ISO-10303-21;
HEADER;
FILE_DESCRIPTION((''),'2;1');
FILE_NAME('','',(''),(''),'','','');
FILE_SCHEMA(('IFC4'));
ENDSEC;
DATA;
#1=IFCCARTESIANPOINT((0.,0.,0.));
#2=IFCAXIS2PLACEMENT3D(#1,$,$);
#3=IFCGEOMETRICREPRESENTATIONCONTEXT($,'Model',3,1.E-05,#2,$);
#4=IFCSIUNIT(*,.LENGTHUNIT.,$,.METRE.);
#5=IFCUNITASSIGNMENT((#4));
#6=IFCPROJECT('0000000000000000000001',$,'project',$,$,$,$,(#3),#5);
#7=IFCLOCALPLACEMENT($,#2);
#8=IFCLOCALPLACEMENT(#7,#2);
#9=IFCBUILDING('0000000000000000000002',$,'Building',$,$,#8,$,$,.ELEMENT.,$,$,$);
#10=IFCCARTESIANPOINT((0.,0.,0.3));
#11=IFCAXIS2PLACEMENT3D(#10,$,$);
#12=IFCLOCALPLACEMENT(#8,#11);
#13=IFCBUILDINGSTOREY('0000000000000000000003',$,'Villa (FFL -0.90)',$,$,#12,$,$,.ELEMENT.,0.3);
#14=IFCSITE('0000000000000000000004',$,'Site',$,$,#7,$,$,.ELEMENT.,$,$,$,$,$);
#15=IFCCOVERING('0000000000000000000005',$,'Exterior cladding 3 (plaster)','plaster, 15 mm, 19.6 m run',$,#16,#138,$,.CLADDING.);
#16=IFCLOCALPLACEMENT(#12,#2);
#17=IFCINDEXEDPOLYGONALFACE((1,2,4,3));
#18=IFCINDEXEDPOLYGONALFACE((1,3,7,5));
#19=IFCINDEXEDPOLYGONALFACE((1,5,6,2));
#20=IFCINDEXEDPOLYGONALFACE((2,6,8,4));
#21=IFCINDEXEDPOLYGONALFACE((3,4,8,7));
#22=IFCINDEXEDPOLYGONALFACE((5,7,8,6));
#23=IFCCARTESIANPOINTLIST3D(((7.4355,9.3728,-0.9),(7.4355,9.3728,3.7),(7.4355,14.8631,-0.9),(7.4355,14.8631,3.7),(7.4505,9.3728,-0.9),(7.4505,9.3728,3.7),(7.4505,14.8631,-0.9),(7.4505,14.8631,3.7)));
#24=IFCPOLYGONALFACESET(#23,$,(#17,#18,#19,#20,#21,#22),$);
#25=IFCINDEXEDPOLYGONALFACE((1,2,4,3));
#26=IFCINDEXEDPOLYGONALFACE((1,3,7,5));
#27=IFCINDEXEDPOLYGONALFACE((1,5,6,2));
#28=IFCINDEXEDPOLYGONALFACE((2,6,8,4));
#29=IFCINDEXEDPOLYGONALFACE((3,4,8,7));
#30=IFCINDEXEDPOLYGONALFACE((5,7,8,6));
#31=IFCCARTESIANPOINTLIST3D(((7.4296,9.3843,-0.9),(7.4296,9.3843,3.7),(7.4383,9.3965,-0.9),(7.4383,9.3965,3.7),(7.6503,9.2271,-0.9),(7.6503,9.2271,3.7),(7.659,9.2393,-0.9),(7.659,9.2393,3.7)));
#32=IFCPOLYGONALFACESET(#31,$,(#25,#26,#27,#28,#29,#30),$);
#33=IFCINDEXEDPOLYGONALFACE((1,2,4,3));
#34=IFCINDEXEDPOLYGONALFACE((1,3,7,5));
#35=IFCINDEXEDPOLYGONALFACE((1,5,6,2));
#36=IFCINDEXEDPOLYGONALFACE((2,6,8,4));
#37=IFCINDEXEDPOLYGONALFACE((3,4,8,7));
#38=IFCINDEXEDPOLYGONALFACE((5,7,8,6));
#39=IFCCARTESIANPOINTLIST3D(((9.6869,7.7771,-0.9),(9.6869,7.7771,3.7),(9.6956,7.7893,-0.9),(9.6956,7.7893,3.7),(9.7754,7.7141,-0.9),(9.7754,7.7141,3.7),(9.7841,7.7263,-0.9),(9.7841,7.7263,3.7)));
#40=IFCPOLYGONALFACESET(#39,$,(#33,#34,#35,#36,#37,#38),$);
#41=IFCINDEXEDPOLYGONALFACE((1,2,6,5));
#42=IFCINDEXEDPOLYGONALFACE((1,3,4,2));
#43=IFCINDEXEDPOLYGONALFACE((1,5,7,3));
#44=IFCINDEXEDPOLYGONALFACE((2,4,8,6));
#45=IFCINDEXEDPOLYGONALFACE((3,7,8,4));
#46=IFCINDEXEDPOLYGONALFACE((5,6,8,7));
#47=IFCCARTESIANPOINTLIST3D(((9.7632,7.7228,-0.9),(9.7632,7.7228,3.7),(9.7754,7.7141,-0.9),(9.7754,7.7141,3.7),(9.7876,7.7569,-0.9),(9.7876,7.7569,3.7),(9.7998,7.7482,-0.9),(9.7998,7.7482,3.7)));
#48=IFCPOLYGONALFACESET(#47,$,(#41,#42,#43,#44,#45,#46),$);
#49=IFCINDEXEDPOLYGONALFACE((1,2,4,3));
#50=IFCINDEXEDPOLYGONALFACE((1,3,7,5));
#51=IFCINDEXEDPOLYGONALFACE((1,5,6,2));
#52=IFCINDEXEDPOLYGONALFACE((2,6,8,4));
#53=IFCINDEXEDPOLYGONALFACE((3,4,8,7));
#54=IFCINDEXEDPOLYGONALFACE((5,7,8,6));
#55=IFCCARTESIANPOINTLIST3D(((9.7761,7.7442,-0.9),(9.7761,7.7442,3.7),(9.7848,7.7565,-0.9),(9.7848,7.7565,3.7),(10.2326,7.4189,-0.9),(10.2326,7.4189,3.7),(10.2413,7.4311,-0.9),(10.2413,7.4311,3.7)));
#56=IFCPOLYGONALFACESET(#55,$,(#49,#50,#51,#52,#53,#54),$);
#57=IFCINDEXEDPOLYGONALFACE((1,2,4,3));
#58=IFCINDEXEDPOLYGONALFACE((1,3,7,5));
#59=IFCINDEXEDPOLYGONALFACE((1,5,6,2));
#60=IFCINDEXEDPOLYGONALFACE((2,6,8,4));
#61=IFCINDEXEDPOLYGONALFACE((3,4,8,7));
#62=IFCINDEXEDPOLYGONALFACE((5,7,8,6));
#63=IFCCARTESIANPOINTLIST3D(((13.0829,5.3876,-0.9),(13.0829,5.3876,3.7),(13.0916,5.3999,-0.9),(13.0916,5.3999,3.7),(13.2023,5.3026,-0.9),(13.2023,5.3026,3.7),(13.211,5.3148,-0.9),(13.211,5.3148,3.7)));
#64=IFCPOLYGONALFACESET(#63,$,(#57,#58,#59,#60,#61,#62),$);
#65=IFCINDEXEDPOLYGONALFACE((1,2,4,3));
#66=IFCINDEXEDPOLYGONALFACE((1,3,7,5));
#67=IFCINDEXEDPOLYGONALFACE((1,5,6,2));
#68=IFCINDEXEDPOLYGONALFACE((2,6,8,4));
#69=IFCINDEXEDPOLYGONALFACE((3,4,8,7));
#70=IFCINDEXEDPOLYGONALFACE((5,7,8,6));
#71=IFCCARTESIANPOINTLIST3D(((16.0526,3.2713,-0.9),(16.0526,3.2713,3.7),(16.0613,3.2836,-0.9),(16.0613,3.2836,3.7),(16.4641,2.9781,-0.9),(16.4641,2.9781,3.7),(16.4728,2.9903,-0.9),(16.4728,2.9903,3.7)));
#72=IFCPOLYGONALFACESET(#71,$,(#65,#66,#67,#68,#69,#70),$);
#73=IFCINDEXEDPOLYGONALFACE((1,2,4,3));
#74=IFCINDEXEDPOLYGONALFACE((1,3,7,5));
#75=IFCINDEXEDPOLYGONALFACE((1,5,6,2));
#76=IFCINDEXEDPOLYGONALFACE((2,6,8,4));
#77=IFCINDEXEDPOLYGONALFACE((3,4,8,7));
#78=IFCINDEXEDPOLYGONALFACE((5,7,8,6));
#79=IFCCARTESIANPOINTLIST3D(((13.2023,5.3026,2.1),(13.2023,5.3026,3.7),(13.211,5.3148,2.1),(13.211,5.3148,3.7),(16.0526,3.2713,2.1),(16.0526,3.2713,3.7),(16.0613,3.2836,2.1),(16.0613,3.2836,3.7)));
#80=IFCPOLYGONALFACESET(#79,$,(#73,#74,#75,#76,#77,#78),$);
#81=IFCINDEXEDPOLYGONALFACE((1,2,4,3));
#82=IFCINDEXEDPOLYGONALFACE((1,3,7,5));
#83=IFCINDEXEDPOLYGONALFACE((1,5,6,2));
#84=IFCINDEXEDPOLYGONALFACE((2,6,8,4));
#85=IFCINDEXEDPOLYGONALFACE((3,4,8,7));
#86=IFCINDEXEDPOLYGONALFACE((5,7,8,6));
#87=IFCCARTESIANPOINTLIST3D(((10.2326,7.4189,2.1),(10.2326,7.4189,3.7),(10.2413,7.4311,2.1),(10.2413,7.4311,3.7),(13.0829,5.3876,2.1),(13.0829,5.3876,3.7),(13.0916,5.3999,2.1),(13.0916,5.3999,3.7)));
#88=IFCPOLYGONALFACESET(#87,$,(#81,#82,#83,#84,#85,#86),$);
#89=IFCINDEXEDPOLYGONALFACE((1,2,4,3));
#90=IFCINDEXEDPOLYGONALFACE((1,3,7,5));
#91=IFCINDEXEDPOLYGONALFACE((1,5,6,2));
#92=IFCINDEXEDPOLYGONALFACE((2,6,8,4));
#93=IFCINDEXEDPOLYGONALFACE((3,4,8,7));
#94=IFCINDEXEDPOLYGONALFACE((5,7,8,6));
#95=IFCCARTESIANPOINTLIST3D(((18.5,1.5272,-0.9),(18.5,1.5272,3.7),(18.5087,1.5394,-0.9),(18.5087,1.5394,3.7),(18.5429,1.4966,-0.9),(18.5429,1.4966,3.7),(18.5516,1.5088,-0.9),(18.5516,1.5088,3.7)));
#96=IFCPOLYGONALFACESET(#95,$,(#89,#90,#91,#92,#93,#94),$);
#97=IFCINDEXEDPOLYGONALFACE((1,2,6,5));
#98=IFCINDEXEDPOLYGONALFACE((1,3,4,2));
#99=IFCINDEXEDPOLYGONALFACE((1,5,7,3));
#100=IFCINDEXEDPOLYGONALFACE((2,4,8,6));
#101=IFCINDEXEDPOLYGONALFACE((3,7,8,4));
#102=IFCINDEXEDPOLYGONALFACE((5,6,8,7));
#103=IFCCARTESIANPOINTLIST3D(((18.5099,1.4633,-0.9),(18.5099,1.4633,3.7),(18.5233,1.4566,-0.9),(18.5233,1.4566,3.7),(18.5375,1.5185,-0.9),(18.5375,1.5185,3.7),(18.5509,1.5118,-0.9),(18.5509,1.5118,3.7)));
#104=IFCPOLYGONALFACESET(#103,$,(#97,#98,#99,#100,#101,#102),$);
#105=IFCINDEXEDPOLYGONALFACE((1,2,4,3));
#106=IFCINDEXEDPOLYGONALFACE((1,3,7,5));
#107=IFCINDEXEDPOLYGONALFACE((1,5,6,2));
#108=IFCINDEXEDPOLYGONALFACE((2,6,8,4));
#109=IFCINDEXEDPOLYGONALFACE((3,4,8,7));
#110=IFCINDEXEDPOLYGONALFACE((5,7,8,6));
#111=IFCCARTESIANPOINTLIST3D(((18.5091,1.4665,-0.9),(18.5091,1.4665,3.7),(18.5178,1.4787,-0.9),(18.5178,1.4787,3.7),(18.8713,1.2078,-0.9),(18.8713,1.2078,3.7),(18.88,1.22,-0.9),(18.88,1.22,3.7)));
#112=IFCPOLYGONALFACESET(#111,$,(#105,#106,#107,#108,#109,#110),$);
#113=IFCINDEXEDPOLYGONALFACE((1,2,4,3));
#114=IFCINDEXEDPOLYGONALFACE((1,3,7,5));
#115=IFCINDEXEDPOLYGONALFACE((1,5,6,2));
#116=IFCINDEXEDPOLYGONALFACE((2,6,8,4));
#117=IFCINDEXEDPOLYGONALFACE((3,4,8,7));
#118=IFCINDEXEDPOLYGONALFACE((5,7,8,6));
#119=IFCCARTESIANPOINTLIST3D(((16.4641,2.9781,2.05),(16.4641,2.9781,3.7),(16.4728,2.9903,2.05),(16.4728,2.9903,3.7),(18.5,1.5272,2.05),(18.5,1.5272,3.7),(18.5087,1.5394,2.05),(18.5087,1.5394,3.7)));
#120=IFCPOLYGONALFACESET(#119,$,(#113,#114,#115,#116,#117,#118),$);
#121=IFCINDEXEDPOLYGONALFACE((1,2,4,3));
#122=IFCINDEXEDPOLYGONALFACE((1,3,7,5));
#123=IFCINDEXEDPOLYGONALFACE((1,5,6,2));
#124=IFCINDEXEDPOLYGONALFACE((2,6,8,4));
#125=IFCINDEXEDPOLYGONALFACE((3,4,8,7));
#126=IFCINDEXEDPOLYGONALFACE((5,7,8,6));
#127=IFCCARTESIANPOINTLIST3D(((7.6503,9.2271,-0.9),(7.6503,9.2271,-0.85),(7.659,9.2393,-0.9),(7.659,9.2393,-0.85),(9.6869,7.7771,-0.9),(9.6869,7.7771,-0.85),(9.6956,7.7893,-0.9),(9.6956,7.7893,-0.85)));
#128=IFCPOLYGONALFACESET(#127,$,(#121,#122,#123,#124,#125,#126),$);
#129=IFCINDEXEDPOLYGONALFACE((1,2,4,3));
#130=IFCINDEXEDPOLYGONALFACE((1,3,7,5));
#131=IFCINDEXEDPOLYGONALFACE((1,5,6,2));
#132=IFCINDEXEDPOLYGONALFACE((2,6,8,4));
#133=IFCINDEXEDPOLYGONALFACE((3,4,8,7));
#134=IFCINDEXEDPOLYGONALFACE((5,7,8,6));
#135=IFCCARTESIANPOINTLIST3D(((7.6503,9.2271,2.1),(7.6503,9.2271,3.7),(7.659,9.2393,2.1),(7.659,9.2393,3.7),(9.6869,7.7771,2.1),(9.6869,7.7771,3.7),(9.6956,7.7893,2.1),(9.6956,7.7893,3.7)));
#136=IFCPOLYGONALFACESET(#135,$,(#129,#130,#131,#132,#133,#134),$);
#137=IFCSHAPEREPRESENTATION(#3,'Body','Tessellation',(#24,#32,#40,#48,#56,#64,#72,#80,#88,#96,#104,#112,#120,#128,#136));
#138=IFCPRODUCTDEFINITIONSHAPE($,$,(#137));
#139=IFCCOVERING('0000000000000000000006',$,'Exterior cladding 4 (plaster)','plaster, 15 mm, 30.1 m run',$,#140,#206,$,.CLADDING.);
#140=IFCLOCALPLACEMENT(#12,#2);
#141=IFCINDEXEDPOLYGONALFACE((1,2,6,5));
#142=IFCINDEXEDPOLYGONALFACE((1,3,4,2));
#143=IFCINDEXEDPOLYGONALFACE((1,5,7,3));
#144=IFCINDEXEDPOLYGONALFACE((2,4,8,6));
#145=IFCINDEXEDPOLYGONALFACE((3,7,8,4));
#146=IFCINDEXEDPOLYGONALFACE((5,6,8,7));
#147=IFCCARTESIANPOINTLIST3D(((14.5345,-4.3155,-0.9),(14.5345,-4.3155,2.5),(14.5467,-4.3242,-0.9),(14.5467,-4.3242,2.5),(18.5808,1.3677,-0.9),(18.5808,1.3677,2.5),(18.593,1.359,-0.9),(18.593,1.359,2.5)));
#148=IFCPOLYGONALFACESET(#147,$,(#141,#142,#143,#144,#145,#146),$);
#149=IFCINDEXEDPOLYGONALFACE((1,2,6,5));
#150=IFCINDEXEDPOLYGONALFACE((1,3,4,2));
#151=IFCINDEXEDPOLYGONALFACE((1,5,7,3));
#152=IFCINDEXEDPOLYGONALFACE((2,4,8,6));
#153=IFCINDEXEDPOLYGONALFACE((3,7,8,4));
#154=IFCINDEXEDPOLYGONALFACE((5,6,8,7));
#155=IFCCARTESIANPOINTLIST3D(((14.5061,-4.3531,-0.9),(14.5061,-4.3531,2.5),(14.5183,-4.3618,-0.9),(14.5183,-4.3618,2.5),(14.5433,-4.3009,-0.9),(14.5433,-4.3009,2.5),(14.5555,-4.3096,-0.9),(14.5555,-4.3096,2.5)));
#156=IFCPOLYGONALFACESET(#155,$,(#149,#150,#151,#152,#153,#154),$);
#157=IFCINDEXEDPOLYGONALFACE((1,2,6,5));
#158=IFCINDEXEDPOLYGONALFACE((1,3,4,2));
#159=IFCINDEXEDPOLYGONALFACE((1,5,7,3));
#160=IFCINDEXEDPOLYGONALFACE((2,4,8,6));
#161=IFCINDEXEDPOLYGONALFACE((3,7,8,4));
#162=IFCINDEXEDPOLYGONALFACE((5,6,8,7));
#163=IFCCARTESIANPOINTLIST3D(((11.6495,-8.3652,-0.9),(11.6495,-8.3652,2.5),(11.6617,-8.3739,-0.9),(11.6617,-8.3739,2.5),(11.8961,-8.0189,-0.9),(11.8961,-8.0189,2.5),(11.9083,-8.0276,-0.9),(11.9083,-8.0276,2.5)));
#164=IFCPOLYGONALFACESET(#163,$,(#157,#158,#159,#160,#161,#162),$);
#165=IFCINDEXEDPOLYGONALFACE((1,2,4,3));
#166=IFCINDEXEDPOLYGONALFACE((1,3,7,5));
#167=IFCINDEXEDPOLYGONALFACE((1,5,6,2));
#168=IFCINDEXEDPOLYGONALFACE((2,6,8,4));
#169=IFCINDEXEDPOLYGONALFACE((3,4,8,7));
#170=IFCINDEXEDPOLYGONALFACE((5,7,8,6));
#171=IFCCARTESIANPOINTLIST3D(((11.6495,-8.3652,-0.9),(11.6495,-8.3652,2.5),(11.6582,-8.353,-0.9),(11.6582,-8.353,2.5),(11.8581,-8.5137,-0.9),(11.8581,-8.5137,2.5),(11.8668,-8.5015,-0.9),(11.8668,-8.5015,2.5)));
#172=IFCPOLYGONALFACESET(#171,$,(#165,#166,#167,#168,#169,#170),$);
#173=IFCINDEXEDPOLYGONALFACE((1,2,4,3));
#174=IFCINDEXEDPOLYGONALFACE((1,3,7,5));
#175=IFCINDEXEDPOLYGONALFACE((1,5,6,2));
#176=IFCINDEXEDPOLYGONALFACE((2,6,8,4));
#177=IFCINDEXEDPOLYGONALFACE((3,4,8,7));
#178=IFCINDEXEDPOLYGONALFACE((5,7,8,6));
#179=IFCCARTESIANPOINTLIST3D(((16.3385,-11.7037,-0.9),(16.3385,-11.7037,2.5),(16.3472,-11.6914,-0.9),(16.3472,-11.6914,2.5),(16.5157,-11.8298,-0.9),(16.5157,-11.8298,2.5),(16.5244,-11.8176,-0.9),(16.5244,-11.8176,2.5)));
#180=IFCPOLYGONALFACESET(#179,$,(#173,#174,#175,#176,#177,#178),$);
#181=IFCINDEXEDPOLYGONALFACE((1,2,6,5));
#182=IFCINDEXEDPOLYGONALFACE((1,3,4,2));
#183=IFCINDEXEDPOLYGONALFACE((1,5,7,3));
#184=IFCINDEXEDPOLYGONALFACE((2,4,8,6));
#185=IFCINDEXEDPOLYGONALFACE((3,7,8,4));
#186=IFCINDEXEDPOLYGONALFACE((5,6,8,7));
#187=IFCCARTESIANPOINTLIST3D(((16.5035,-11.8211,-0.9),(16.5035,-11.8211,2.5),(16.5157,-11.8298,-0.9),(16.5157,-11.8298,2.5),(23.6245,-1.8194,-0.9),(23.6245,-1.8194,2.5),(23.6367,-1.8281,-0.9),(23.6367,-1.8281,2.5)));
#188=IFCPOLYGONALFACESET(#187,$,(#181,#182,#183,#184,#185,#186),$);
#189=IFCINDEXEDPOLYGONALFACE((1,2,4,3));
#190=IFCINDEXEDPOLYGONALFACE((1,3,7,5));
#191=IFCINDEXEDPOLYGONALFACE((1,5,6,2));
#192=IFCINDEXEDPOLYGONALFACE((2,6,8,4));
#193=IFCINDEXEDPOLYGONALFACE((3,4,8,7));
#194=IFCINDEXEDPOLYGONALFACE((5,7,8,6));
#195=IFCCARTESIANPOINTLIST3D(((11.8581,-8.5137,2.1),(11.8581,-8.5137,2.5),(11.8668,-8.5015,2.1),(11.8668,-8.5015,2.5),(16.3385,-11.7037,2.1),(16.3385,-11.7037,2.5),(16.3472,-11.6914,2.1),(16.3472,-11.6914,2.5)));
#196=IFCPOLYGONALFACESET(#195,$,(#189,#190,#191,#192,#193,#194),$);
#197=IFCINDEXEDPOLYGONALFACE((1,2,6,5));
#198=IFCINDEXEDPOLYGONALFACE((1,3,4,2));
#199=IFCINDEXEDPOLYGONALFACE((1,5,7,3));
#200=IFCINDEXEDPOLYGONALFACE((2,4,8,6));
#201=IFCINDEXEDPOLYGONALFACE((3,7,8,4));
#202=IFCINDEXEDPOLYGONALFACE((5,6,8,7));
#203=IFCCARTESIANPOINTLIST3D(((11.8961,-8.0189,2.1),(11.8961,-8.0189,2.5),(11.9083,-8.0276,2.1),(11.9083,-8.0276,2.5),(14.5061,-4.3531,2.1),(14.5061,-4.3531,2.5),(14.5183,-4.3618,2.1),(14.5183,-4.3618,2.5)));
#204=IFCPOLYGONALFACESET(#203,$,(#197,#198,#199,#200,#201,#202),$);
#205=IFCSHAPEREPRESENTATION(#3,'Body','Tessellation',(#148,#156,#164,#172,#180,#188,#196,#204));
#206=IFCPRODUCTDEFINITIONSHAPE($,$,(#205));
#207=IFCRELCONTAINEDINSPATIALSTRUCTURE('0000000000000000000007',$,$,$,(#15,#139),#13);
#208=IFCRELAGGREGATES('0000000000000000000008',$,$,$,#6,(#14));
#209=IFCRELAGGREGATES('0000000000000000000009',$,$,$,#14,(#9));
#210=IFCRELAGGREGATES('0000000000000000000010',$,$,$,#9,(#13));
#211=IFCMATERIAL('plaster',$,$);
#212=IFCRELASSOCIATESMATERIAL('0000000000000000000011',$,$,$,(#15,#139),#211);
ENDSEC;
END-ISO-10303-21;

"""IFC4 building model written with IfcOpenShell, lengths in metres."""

from ifc_helpers import new_model, si_unit, frame, origin, origin_with_axes, place, context, project, spatial, polyline, outline, extrude, material, element, save


model = new_model("IFC4")

# Units and contexts
model_context = context("Model", 3, precision=1e-05, world=origin())
ifc_project = project(units=[si_unit("LENGTHUNIT", "METRE")], contexts=[model_context])

# Site, building, storey
site_placement = place(None, origin())
site = spatial("IfcSite", under=ifc_project, at=site_placement, Name="Site", CompositionType="ELEMENT")
building_placement = place(site_placement, origin())
building = spatial("IfcBuilding", under=site, at=building_placement, Name="Building", CompositionType="ELEMENT")
storey_placement = place(building_placement, frame((0.0, 0.0, 0.3)))
storey = spatial("IfcBuildingStorey", under=building, at=storey_placement, Name="Villa (FFL -0.90)", CompositionType="ELEMENT", Elevation=0.3)

# Coverings
ifc_material_1 = material(Name="plaster")
covering_1_placement = place(storey_placement, origin_with_axes())
element("IfcCovering", 1, at=covering_1_placement, inside=storey, material=ifc_material_1, Name="Exterior cladding 3 (plaster)", Description="plaster, 15 mm, 19.6 m run", PredefinedType="CLADDING", context=model_context, shape_type="SweptSolid", body=[
    extrude(outline(polyline([(7.4355, 14.8631), (7.4355, 9.3728), (7.4505, 9.3728), (7.4505, 14.8631), (7.4355, 14.8631)])), frame((0.0, 0.0, -0.9)), (0.0, 0.0, 1.0), 4.6),
    extrude(outline(polyline([(7.4296, 9.3843), (7.6503, 9.2271), (7.659, 9.2393), (7.4383, 9.3965), (7.4296, 9.3843)])), frame((0.0, 0.0, -0.9)), (0.0, 0.0, 1.0), 4.6),
    extrude(outline(polyline([(9.6869, 7.7771), (9.7754, 7.7141), (9.7841, 7.7263), (9.6956, 7.7893), (9.6869, 7.7771)])), frame((0.0, 0.0, -0.9)), (0.0, 0.0, 1.0), 4.6),
    extrude(outline(polyline([(9.7754, 7.7141), (9.7998, 7.7482), (9.7876, 7.7569), (9.7632, 7.7228), (9.7754, 7.7141)])), frame((0.0, 0.0, -0.9)), (0.0, 0.0, 1.0), 4.6),
    extrude(outline(polyline([(9.7761, 7.7442), (10.2326, 7.4189), (10.2413, 7.4311), (9.7848, 7.7565), (9.7761, 7.7442)])), frame((0.0, 0.0, -0.9)), (0.0, 0.0, 1.0), 4.6),
    extrude(outline(polyline([(13.0829, 5.3876), (13.2023, 5.3026), (13.211, 5.3148), (13.0916, 5.3999), (13.0829, 5.3876)])), frame((0.0, 0.0, -0.9)), (0.0, 0.0, 1.0), 4.6),
    extrude(outline(polyline([(16.0526, 3.2713), (16.4641, 2.9781), (16.4728, 2.9903), (16.0613, 3.2836), (16.0526, 3.2713)])), frame((0.0, 0.0, -0.9)), (0.0, 0.0, 1.0), 4.6),
    extrude(outline(polyline([(13.2023, 5.3026), (16.0526, 3.2713), (16.0613, 3.2836), (13.211, 5.3148), (13.2023, 5.3026)])), frame((0.0, 0.0, 2.1)), (0.0, 0.0, 1.0), 1.6),
    extrude(outline(polyline([(10.2326, 7.4189), (13.0829, 5.3876), (13.0916, 5.3999), (10.2413, 7.4311), (10.2326, 7.4189)])), frame((0.0, 0.0, 2.1)), (0.0, 0.0, 1.0), 1.6),
    extrude(outline(polyline([(18.5, 1.5272), (18.5429, 1.4966), (18.5516, 1.5088), (18.5087, 1.5394), (18.5, 1.5272)])), frame((0.0, 0.0, -0.9)), (0.0, 0.0, 1.0), 4.6),
    extrude(outline(polyline([(18.5375, 1.5185), (18.5099, 1.4633), (18.5233, 1.4566), (18.5509, 1.5118), (18.5375, 1.5185)])), frame((0.0, 0.0, -0.9)), (0.0, 0.0, 1.0), 4.6),
    extrude(outline(polyline([(18.5091, 1.4665), (18.8713, 1.2078), (18.88, 1.22), (18.5178, 1.4787), (18.5091, 1.4665)])), frame((0.0, 0.0, -0.9)), (0.0, 0.0, 1.0), 4.6),
    extrude(outline(polyline([(16.4641, 2.9781), (18.5, 1.5272), (18.5087, 1.5394), (16.4728, 2.9903), (16.4641, 2.9781)])), frame((0.0, 0.0, 2.05)), (0.0, 0.0, 1.0), 1.65),
    extrude(outline(polyline([(7.6503, 9.2271), (9.6869, 7.7771), (9.6956, 7.7893), (7.659, 9.2393), (7.6503, 9.2271)])), frame((0.0, 0.0, -0.9)), (0.0, 0.0, 1.0), 0.05),
    extrude(outline(polyline([(7.6503, 9.2271), (9.6869, 7.7771), (9.6956, 7.7893), (7.659, 9.2393), (7.6503, 9.2271)])), frame((0.0, 0.0, 2.1)), (0.0, 0.0, 1.0), 1.6),
])
covering_2_placement = place(storey_placement, origin_with_axes())
element("IfcCovering", 2, at=covering_2_placement, inside=storey, material=ifc_material_1, Name="Exterior cladding 4 (plaster)", Description="plaster, 15 mm, 30.1 m run", PredefinedType="CLADDING", context=model_context, shape_type="SweptSolid", body=[
    extrude(outline(polyline([(18.5808, 1.3677), (14.5345, -4.3155), (14.5467, -4.3242), (18.593, 1.359), (18.5808, 1.3677)])), frame((0.0, 0.0, -0.9)), (0.0, 0.0, 1.0), 3.4),
    extrude(outline(polyline([(14.5433, -4.3009), (14.5061, -4.3531), (14.5183, -4.3618), (14.5555, -4.3096), (14.5433, -4.3009)])), frame((0.0, 0.0, -0.9)), (0.0, 0.0, 1.0), 3.4),
    extrude(outline(polyline([(11.8961, -8.0189), (11.6495, -8.3652), (11.6617, -8.3739), (11.9083, -8.0276), (11.8961, -8.0189)])), frame((0.0, 0.0, -0.9)), (0.0, 0.0, 1.0), 3.4),
    extrude(outline(polyline([(11.6495, -8.3652), (11.8581, -8.5137), (11.8668, -8.5015), (11.6582, -8.353), (11.6495, -8.3652)])), frame((0.0, 0.0, -0.9)), (0.0, 0.0, 1.0), 3.4),
    extrude(outline(polyline([(16.3385, -11.7037), (16.5157, -11.8298), (16.5244, -11.8176), (16.3472, -11.6914), (16.3385, -11.7037)])), frame((0.0, 0.0, -0.9)), (0.0, 0.0, 1.0), 3.4),
    extrude(outline(polyline([(16.5157, -11.8298), (23.6367, -1.8281), (23.6245, -1.8194), (16.5035, -11.8211), (16.5157, -11.8298)])), frame((0.0, 0.0, -0.9)), (0.0, 0.0, 1.0), 3.4),
    extrude(outline(polyline([(11.8581, -8.5137), (16.3385, -11.7037), (16.3472, -11.6914), (11.8668, -8.5015), (11.8581, -8.5137)])), frame((0.0, 0.0, 2.1)), (0.0, 0.0, 1.0), 0.4),
    extrude(outline(polyline([(14.5061, -4.3531), (11.8961, -8.0189), (11.9083, -8.0276), (14.5183, -4.3618), (14.5061, -4.3531)])), frame((0.0, 0.0, 2.1)), (0.0, 0.0, 1.0), 0.4),
])

save(model, "model.ifc")
